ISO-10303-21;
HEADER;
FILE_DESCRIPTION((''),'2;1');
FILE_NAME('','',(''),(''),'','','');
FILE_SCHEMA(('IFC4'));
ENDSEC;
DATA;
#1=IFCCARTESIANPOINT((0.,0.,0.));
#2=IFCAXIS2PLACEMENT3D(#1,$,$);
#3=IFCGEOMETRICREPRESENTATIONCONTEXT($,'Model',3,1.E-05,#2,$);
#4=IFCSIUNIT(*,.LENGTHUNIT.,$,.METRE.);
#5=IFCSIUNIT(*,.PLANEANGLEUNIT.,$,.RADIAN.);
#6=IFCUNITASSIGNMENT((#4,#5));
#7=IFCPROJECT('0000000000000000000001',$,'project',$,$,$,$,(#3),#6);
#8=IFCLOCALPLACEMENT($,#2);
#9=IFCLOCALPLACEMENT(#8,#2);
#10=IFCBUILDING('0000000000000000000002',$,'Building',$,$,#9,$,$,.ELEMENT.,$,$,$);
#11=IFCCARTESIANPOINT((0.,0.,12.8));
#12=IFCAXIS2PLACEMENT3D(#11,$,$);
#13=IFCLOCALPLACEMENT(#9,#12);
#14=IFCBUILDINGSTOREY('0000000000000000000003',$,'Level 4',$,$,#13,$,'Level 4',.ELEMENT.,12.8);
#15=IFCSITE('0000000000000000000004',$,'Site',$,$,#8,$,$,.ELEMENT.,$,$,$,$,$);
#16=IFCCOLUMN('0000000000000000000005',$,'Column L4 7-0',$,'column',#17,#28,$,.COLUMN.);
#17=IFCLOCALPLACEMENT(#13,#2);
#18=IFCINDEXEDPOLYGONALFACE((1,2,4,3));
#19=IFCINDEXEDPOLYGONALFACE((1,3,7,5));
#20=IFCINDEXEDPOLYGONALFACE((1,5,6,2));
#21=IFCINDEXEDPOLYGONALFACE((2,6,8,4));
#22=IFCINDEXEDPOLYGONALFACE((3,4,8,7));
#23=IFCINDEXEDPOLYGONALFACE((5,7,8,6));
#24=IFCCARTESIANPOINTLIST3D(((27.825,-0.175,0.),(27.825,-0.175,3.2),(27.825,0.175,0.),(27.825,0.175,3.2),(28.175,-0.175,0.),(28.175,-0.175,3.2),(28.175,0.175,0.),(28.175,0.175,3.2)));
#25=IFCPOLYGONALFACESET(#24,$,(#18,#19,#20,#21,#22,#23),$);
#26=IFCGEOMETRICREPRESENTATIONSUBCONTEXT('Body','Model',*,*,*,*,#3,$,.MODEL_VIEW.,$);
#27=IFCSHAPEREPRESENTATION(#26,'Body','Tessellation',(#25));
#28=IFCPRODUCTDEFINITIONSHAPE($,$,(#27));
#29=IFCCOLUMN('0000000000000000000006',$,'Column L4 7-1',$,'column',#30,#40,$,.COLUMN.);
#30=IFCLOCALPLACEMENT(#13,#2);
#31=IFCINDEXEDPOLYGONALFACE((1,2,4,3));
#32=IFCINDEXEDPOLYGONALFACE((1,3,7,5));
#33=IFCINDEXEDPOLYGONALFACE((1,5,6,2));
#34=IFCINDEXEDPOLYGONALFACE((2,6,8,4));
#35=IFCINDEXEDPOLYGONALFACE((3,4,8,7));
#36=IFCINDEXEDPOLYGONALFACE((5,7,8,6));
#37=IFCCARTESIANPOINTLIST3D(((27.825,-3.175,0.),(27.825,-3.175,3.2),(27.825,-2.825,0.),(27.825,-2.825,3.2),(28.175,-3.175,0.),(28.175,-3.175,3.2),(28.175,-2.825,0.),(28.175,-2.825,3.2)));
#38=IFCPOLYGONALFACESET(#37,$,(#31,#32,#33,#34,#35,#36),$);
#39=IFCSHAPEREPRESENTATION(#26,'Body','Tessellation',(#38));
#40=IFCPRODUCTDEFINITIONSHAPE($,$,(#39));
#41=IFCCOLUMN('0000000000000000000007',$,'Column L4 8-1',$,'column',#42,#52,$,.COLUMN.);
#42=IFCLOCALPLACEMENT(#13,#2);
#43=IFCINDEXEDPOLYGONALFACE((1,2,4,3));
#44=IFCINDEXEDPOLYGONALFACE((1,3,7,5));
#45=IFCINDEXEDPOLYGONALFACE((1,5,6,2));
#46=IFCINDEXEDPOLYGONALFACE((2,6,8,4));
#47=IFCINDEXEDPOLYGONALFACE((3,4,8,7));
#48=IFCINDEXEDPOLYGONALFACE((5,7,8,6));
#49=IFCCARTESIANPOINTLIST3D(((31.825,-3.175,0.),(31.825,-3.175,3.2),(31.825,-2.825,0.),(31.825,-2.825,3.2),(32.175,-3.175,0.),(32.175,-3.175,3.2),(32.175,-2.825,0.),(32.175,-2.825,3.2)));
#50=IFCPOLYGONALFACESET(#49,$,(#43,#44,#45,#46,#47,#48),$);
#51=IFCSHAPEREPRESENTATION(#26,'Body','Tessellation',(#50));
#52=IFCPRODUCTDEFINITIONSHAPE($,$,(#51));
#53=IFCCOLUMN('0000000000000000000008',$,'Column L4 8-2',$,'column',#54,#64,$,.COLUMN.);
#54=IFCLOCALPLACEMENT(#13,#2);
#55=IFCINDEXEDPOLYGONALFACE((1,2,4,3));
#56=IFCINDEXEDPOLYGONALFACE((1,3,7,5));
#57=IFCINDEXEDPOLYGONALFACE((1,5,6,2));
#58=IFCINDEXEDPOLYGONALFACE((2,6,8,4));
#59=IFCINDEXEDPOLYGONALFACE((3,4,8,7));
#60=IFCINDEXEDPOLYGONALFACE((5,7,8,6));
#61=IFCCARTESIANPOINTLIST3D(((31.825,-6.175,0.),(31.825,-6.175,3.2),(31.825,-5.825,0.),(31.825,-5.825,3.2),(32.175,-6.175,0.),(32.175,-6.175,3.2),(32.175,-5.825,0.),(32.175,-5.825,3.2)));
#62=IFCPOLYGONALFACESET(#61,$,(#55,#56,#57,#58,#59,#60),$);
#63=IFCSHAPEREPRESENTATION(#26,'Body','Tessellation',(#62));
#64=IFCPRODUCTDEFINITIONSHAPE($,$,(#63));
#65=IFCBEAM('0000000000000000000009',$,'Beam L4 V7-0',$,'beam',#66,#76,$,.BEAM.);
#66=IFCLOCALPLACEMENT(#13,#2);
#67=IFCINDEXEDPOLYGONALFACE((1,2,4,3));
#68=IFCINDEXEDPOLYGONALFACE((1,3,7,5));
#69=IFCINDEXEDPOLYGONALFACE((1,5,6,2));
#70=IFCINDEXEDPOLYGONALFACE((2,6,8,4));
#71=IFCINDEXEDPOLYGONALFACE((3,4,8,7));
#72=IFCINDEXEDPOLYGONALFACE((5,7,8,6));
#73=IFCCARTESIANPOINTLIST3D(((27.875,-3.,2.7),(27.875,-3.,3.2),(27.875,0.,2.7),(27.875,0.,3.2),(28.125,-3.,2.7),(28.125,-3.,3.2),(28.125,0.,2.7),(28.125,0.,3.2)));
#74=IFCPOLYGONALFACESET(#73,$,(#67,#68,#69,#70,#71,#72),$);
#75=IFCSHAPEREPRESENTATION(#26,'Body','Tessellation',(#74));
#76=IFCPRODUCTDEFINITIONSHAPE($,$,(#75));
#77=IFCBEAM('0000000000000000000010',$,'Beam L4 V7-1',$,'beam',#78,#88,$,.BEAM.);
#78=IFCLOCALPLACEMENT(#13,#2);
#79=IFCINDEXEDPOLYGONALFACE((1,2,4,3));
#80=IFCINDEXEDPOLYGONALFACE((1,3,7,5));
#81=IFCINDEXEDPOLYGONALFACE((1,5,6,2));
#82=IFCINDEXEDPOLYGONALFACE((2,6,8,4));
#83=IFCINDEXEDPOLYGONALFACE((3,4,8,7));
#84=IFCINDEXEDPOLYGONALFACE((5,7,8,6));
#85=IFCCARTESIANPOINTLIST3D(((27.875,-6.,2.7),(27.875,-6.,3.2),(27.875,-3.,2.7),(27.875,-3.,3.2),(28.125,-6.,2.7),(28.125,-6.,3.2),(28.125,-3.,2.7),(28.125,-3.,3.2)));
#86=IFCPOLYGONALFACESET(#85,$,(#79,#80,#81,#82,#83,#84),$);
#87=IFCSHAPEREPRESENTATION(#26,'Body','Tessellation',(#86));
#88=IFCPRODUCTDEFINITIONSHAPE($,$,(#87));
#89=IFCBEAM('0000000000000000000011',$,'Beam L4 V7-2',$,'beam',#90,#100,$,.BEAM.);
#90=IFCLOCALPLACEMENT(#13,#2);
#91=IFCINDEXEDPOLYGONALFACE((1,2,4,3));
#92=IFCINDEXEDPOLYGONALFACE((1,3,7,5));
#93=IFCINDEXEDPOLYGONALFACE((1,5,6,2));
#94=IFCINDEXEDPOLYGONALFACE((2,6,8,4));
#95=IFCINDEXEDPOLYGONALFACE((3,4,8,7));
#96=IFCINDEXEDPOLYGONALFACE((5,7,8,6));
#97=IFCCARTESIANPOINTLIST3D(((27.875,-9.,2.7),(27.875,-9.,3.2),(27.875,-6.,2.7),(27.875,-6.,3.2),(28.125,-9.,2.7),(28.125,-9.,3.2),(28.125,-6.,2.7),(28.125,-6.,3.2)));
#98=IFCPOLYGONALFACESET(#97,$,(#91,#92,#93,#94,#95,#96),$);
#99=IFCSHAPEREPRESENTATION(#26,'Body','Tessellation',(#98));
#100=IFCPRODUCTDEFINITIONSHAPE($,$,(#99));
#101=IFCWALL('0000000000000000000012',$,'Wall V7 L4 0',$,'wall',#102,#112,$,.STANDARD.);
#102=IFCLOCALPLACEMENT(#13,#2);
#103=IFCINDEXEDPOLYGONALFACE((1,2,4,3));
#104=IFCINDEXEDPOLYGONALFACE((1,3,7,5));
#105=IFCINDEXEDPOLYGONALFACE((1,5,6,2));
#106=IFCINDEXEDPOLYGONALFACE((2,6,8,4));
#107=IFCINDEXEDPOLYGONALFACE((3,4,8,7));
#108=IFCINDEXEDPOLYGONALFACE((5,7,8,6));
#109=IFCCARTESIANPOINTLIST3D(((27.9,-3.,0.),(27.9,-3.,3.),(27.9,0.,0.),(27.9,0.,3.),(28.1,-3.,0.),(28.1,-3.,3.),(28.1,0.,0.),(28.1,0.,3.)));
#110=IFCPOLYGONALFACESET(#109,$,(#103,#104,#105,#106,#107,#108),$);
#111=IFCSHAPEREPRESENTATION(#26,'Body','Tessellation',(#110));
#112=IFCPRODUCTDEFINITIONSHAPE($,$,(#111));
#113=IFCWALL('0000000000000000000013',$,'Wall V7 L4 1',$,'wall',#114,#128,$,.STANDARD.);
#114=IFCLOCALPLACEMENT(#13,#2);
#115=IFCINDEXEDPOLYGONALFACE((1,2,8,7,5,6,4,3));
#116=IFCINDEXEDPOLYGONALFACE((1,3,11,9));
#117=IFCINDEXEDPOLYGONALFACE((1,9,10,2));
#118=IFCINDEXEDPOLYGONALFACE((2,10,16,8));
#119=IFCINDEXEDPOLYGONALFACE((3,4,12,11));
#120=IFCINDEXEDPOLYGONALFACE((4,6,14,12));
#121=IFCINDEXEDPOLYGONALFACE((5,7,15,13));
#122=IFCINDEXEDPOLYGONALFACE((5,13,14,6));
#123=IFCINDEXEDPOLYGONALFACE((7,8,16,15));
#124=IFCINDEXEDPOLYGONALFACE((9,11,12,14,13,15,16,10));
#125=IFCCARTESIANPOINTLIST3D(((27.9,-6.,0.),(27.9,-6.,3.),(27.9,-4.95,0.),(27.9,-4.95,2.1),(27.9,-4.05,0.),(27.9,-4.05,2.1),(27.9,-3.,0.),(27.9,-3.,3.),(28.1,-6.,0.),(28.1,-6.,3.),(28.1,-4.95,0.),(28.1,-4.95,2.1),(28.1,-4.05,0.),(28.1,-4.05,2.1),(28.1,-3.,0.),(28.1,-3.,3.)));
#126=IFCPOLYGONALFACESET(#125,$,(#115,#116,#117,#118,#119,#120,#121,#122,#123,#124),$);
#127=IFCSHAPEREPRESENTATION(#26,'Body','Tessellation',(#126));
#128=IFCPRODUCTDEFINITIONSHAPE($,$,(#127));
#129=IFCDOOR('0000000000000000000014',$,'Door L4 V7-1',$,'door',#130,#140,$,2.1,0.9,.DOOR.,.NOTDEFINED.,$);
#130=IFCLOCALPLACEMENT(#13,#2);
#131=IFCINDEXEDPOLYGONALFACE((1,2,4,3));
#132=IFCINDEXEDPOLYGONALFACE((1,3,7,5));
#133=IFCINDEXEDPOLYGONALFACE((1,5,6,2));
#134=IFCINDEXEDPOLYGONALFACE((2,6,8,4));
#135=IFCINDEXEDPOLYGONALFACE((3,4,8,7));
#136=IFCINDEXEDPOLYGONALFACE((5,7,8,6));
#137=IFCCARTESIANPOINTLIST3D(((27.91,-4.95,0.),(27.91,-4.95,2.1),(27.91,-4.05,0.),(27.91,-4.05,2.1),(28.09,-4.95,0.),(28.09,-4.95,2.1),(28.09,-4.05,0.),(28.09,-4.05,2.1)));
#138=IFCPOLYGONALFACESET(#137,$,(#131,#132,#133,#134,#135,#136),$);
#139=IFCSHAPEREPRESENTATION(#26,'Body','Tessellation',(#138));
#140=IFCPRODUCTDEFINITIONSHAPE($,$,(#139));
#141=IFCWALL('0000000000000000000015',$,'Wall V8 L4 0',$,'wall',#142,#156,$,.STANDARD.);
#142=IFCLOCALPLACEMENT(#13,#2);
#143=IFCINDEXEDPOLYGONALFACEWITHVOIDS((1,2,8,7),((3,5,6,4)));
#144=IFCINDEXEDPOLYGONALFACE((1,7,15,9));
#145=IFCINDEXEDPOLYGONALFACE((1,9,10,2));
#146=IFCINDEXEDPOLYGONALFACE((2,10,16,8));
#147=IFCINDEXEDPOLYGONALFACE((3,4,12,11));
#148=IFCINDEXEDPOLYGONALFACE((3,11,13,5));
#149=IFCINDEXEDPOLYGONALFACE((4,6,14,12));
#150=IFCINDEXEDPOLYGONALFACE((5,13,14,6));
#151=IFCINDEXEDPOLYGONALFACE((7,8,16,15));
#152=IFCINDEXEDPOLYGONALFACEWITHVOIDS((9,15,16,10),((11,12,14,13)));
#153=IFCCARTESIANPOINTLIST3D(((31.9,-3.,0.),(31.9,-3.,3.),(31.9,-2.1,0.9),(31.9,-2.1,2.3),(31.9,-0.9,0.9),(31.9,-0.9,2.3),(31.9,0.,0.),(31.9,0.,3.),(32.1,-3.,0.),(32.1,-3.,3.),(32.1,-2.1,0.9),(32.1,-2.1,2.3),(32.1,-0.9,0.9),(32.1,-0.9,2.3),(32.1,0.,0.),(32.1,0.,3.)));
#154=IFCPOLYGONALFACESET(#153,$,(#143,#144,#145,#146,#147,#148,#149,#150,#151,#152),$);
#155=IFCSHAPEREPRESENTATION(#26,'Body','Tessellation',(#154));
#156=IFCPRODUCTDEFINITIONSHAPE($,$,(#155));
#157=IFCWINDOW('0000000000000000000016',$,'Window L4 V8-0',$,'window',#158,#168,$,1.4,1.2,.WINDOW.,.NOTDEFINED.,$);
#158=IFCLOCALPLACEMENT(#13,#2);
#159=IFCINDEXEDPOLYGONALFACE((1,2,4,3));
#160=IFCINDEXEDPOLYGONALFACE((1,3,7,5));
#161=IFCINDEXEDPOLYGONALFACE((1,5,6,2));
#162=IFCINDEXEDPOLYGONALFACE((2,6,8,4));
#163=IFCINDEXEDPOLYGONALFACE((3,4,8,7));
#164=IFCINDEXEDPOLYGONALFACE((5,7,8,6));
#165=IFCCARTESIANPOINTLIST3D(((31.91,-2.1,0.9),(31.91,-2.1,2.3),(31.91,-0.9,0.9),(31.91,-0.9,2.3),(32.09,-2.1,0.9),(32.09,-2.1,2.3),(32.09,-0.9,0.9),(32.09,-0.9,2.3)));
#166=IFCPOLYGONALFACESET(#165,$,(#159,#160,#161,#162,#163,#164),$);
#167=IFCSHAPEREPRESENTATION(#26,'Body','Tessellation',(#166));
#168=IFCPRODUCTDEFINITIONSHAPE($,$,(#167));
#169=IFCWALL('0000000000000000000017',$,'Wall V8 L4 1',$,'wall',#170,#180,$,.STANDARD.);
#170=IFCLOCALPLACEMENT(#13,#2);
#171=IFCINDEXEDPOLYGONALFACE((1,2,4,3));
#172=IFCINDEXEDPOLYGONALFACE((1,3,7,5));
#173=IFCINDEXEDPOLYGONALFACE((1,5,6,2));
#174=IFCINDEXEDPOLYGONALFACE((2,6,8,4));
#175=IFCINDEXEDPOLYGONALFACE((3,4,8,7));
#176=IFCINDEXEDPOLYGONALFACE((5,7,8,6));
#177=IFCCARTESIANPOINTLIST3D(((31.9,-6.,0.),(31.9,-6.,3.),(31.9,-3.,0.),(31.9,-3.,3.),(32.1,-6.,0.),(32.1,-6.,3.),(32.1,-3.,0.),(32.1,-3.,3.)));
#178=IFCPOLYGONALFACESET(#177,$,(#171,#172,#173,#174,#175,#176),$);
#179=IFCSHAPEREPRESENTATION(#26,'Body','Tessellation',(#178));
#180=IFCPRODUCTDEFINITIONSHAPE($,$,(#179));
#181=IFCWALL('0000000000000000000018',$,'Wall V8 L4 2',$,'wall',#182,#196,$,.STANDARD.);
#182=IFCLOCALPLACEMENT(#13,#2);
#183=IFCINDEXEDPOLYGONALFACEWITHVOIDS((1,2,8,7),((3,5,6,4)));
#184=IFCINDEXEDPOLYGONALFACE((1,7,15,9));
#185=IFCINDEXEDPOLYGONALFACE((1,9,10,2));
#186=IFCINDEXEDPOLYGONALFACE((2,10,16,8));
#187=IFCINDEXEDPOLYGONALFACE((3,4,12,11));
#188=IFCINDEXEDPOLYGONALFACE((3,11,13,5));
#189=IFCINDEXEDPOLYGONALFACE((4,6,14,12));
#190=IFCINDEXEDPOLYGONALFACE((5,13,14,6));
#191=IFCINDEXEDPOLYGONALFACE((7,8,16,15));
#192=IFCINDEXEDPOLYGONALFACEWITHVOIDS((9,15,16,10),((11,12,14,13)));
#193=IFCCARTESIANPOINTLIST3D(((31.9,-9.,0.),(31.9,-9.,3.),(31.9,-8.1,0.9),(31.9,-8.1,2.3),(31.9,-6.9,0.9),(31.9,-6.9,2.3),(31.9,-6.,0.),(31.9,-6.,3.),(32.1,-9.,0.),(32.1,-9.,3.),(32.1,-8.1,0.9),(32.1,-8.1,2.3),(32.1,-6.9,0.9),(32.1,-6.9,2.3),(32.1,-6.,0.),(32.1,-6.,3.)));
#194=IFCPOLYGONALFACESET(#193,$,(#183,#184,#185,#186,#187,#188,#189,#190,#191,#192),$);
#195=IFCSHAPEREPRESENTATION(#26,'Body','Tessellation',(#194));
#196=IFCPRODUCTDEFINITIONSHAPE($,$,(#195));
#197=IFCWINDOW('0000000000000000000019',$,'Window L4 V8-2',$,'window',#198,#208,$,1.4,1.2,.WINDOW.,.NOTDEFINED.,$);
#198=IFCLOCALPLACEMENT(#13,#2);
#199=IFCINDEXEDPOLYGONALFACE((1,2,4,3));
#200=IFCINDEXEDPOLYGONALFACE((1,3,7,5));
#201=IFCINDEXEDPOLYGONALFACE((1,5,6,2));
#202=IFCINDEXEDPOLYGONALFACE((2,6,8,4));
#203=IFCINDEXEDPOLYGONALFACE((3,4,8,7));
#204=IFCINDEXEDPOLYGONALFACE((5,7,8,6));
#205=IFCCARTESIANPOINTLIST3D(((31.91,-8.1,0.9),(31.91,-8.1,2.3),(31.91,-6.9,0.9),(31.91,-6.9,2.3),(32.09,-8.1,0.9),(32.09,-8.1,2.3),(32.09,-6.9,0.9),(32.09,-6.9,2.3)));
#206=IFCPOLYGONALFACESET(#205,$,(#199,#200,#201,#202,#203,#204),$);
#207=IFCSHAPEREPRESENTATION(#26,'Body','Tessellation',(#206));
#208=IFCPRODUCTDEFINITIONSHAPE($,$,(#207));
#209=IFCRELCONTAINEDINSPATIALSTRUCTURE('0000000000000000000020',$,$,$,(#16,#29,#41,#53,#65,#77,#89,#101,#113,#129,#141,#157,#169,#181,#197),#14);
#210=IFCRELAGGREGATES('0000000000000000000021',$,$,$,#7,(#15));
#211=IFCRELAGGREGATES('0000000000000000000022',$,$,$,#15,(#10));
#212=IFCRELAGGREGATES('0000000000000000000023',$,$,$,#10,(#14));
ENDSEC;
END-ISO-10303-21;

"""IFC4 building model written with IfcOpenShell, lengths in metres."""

from ifc_helpers import new_model, si_unit, frame, frame_2d, origin, origin_2d, place, context, subcontext, project, spatial, rectangle, extrude, element, fill, save


model = new_model("IFC4")

# Units and contexts
model_context = context("Model", 3, precision=1e-05, world=origin())
body_context = subcontext(model_context, "Body", "Model", "MODEL_VIEW")
ifc_project = project(units=[si_unit("LENGTHUNIT", "METRE"), si_unit("PLANEANGLEUNIT", "RADIAN")], contexts=[model_context])

# Site, building, storey
site_placement = place(None, origin())
site = spatial("IfcSite", under=ifc_project, at=site_placement, Name="Site", CompositionType="ELEMENT")
building_placement = place(site_placement, origin())
building = spatial("IfcBuilding", under=site, at=building_placement, Name="Building", CompositionType="ELEMENT")
storey_placement = place(building_placement, frame((0.0, 0.0, 12.8)))
storey = spatial("IfcBuildingStorey", under=building, at=storey_placement, Name="Level 4", LongName="Level 4", CompositionType="ELEMENT", Elevation=12.8)

# Columns
for number, where, name in (
    (1, (28.0, 0.0, 0.0), "Column L4 7-0"),
    (2, (28.0, -3.0, 0.0), "Column L4 7-1"),
    (3, (32.0, -3.0, 0.0), "Column L4 8-1"),
    (4, (32.0, -6.0, 0.0), "Column L4 8-2"),
):
    element("IfcColumn", number, at=place(storey_placement, frame(where)), inside=storey, Name=name, ObjectType="column", PredefinedType="COLUMN", context=body_context, shape_type="SweptSolid", body=[
        extrude(rectangle(XDim=0.35, YDim=0.35, at=origin_2d()), origin(), (0.0, 0.0, 1.0), 3.2),
    ])

# Beams
for number, where, z_axis, x_axis, name in (
    (5, (28.0, 0.0, 2.95), (0.0, -1.0, 0.0), (0.0, 0.0, 1.0), "Beam L4 V7-0"),
    (6, (28.0, -3.0, 2.95), (0.0, -1.0, 0.0), (0.0, 0.0, 1.0), "Beam L4 V7-1"),
    (7, (28.0, -6.0, 2.95), (0.0, -1.0, 0.0), (0.0, 0.0, 1.0), "Beam L4 V7-2"),
):
    element("IfcBeam", number, at=place(storey_placement, frame(where, z_axis=z_axis, x_axis=x_axis)), inside=storey, Name=name, ObjectType="beam", PredefinedType="BEAM", context=body_context, shape_type="SweptSolid", body=[
        extrude(rectangle(XDim=0.5, YDim=0.25, at=origin_2d()), origin(), (0.0, 0.0, 1.0), 3.0),
    ])

# Wall
wall_1_placement = place(storey_placement, frame((28.0, 0.0, 0.0), z_axis=(0.0, 0.0, 1.0), x_axis=(0.0, -1.0, 0.0)))
element("IfcWall", 8, at=wall_1_placement, inside=storey, Name="Wall V7 L4 0", ObjectType="wall", PredefinedType="STANDARD", context=body_context, shape_type="SweptSolid", body=[
    extrude(rectangle(XDim=3.0, YDim=0.2, at=frame_2d((1.5, 0.0))), origin(), (0.0, 0.0, 1.0), 3.0),
])

# Wall, opening, door
wall_2_placement = place(storey_placement, frame((28.0, -3.0, 0.0), z_axis=(0.0, 0.0, 1.0), x_axis=(0.0, -1.0, 0.0)))
wall_2 = element("IfcWall", 9, at=wall_2_placement, inside=storey, Name="Wall V7 L4 1", ObjectType="wall", PredefinedType="STANDARD", context=body_context, shape_type="SweptSolid", body=[
    extrude(rectangle(XDim=3.0, YDim=0.2, at=frame_2d((1.5, 0.0))), origin(), (0.0, 0.0, 1.0), 3.0),
])
opening_1_placement = place(storey_placement, frame((28.0, -4.5, 0.0), z_axis=(0.0, 0.0, 1.0), x_axis=(0.0, -1.0, 0.0)))
opening_1 = element("IfcOpeningElement", 10, at=opening_1_placement, cuts=wall_2, ObjectType="Opening", PredefinedType="OPENING", context=body_context, shape_type="SweptSolid", body=[
    extrude(rectangle(XDim=0.9, YDim=0.22, at=origin_2d()), origin(), (0.0, 0.0, 1.0), 2.1),
])
door_placement = place(storey_placement, frame((28.0, -4.5, 0.0), z_axis=(0.0, 0.0, 1.0), x_axis=(0.0, -1.0, 0.0)))
door = element("IfcDoor", 11, at=door_placement, inside=storey, Name="Door L4 V7-1", ObjectType="door", OperationType="NOTDEFINED", OverallHeight=2.1, OverallWidth=0.9, PredefinedType="DOOR", context=body_context, shape_type="SweptSolid", body=[
    extrude(rectangle(XDim=0.9, YDim=0.18, at=origin_2d()), origin(), (0.0, 0.0, 1.0), 2.1),
])
fill(opening_1, door)

# Wall, opening, window
wall_3_placement = place(storey_placement, frame((32.0, 0.0, 0.0), z_axis=(0.0, 0.0, 1.0), x_axis=(0.0, -1.0, 0.0)))
wall_3 = element("IfcWall", 12, at=wall_3_placement, inside=storey, Name="Wall V8 L4 0", ObjectType="wall", PredefinedType="STANDARD", context=body_context, shape_type="SweptSolid", body=[
    extrude(rectangle(XDim=3.0, YDim=0.2, at=frame_2d((1.5, 0.0))), origin(), (0.0, 0.0, 1.0), 3.0),
])
opening_2_placement = place(storey_placement, frame((32.0, -1.5, 0.9), z_axis=(0.0, 0.0, 1.0), x_axis=(0.0, -1.0, 0.0)))
opening_2 = element("IfcOpeningElement", 13, at=opening_2_placement, cuts=wall_3, ObjectType="Opening", PredefinedType="OPENING", context=body_context, shape_type="SweptSolid", body=[
    extrude(rectangle(XDim=1.2, YDim=0.22, at=origin_2d()), origin(), (0.0, 0.0, 1.0), 1.4),
])
window_1_placement = place(storey_placement, frame((32.0, -1.5, 0.9), z_axis=(0.0, 0.0, 1.0), x_axis=(0.0, -1.0, 0.0)))
window_1 = element("IfcWindow", 14, at=window_1_placement, inside=storey, Name="Window L4 V8-0", ObjectType="window", OverallHeight=1.4, OverallWidth=1.2, PartitioningType="NOTDEFINED", PredefinedType="WINDOW", context=body_context, shape_type="SweptSolid", body=[
    extrude(rectangle(XDim=1.2, YDim=0.18, at=origin_2d()), origin(), (0.0, 0.0, 1.0), 1.4),
])
fill(opening_2, window_1)

# Wall
wall_4_placement = place(storey_placement, frame((32.0, -3.0, 0.0), z_axis=(0.0, 0.0, 1.0), x_axis=(0.0, -1.0, 0.0)))
element("IfcWall", 15, at=wall_4_placement, inside=storey, Name="Wall V8 L4 1", ObjectType="wall", PredefinedType="STANDARD", context=body_context, shape_type="SweptSolid", body=[
    extrude(rectangle(XDim=3.0, YDim=0.2, at=frame_2d((1.5, 0.0))), origin(), (0.0, 0.0, 1.0), 3.0),
])

# Wall, opening, window
wall_5_placement = place(storey_placement, frame((32.0, -6.0, 0.0), z_axis=(0.0, 0.0, 1.0), x_axis=(0.0, -1.0, 0.0)))
wall_5 = element("IfcWall", 16, at=wall_5_placement, inside=storey, Name="Wall V8 L4 2", ObjectType="wall", PredefinedType="STANDARD", context=body_context, shape_type="SweptSolid", body=[
    extrude(rectangle(XDim=3.0, YDim=0.2, at=frame_2d((1.5, 0.0))), origin(), (0.0, 0.0, 1.0), 3.0),
])
opening_3_placement = place(storey_placement, frame((32.0, -7.5, 0.9), z_axis=(0.0, 0.0, 1.0), x_axis=(0.0, -1.0, 0.0)))
opening_3 = element("IfcOpeningElement", 17, at=opening_3_placement, cuts=wall_5, ObjectType="Opening", PredefinedType="OPENING", context=body_context, shape_type="SweptSolid", body=[
    extrude(rectangle(XDim=1.2, YDim=0.22, at=origin_2d()), origin(), (0.0, 0.0, 1.0), 1.4),
])
window_2_placement = place(storey_placement, frame((32.0, -7.5, 0.9), z_axis=(0.0, 0.0, 1.0), x_axis=(0.0, -1.0, 0.0)))
window_2 = element("IfcWindow", 18, at=window_2_placement, inside=storey, Name="Window L4 V8-2", ObjectType="window", OverallHeight=1.4, OverallWidth=1.2, PartitioningType="NOTDEFINED", PredefinedType="WINDOW", context=body_context, shape_type="SweptSolid", body=[
    extrude(rectangle(XDim=1.2, YDim=0.18, at=origin_2d()), origin(), (0.0, 0.0, 1.0), 1.4),
])
fill(opening_3, window_2)

save(model, "model.ifc")
